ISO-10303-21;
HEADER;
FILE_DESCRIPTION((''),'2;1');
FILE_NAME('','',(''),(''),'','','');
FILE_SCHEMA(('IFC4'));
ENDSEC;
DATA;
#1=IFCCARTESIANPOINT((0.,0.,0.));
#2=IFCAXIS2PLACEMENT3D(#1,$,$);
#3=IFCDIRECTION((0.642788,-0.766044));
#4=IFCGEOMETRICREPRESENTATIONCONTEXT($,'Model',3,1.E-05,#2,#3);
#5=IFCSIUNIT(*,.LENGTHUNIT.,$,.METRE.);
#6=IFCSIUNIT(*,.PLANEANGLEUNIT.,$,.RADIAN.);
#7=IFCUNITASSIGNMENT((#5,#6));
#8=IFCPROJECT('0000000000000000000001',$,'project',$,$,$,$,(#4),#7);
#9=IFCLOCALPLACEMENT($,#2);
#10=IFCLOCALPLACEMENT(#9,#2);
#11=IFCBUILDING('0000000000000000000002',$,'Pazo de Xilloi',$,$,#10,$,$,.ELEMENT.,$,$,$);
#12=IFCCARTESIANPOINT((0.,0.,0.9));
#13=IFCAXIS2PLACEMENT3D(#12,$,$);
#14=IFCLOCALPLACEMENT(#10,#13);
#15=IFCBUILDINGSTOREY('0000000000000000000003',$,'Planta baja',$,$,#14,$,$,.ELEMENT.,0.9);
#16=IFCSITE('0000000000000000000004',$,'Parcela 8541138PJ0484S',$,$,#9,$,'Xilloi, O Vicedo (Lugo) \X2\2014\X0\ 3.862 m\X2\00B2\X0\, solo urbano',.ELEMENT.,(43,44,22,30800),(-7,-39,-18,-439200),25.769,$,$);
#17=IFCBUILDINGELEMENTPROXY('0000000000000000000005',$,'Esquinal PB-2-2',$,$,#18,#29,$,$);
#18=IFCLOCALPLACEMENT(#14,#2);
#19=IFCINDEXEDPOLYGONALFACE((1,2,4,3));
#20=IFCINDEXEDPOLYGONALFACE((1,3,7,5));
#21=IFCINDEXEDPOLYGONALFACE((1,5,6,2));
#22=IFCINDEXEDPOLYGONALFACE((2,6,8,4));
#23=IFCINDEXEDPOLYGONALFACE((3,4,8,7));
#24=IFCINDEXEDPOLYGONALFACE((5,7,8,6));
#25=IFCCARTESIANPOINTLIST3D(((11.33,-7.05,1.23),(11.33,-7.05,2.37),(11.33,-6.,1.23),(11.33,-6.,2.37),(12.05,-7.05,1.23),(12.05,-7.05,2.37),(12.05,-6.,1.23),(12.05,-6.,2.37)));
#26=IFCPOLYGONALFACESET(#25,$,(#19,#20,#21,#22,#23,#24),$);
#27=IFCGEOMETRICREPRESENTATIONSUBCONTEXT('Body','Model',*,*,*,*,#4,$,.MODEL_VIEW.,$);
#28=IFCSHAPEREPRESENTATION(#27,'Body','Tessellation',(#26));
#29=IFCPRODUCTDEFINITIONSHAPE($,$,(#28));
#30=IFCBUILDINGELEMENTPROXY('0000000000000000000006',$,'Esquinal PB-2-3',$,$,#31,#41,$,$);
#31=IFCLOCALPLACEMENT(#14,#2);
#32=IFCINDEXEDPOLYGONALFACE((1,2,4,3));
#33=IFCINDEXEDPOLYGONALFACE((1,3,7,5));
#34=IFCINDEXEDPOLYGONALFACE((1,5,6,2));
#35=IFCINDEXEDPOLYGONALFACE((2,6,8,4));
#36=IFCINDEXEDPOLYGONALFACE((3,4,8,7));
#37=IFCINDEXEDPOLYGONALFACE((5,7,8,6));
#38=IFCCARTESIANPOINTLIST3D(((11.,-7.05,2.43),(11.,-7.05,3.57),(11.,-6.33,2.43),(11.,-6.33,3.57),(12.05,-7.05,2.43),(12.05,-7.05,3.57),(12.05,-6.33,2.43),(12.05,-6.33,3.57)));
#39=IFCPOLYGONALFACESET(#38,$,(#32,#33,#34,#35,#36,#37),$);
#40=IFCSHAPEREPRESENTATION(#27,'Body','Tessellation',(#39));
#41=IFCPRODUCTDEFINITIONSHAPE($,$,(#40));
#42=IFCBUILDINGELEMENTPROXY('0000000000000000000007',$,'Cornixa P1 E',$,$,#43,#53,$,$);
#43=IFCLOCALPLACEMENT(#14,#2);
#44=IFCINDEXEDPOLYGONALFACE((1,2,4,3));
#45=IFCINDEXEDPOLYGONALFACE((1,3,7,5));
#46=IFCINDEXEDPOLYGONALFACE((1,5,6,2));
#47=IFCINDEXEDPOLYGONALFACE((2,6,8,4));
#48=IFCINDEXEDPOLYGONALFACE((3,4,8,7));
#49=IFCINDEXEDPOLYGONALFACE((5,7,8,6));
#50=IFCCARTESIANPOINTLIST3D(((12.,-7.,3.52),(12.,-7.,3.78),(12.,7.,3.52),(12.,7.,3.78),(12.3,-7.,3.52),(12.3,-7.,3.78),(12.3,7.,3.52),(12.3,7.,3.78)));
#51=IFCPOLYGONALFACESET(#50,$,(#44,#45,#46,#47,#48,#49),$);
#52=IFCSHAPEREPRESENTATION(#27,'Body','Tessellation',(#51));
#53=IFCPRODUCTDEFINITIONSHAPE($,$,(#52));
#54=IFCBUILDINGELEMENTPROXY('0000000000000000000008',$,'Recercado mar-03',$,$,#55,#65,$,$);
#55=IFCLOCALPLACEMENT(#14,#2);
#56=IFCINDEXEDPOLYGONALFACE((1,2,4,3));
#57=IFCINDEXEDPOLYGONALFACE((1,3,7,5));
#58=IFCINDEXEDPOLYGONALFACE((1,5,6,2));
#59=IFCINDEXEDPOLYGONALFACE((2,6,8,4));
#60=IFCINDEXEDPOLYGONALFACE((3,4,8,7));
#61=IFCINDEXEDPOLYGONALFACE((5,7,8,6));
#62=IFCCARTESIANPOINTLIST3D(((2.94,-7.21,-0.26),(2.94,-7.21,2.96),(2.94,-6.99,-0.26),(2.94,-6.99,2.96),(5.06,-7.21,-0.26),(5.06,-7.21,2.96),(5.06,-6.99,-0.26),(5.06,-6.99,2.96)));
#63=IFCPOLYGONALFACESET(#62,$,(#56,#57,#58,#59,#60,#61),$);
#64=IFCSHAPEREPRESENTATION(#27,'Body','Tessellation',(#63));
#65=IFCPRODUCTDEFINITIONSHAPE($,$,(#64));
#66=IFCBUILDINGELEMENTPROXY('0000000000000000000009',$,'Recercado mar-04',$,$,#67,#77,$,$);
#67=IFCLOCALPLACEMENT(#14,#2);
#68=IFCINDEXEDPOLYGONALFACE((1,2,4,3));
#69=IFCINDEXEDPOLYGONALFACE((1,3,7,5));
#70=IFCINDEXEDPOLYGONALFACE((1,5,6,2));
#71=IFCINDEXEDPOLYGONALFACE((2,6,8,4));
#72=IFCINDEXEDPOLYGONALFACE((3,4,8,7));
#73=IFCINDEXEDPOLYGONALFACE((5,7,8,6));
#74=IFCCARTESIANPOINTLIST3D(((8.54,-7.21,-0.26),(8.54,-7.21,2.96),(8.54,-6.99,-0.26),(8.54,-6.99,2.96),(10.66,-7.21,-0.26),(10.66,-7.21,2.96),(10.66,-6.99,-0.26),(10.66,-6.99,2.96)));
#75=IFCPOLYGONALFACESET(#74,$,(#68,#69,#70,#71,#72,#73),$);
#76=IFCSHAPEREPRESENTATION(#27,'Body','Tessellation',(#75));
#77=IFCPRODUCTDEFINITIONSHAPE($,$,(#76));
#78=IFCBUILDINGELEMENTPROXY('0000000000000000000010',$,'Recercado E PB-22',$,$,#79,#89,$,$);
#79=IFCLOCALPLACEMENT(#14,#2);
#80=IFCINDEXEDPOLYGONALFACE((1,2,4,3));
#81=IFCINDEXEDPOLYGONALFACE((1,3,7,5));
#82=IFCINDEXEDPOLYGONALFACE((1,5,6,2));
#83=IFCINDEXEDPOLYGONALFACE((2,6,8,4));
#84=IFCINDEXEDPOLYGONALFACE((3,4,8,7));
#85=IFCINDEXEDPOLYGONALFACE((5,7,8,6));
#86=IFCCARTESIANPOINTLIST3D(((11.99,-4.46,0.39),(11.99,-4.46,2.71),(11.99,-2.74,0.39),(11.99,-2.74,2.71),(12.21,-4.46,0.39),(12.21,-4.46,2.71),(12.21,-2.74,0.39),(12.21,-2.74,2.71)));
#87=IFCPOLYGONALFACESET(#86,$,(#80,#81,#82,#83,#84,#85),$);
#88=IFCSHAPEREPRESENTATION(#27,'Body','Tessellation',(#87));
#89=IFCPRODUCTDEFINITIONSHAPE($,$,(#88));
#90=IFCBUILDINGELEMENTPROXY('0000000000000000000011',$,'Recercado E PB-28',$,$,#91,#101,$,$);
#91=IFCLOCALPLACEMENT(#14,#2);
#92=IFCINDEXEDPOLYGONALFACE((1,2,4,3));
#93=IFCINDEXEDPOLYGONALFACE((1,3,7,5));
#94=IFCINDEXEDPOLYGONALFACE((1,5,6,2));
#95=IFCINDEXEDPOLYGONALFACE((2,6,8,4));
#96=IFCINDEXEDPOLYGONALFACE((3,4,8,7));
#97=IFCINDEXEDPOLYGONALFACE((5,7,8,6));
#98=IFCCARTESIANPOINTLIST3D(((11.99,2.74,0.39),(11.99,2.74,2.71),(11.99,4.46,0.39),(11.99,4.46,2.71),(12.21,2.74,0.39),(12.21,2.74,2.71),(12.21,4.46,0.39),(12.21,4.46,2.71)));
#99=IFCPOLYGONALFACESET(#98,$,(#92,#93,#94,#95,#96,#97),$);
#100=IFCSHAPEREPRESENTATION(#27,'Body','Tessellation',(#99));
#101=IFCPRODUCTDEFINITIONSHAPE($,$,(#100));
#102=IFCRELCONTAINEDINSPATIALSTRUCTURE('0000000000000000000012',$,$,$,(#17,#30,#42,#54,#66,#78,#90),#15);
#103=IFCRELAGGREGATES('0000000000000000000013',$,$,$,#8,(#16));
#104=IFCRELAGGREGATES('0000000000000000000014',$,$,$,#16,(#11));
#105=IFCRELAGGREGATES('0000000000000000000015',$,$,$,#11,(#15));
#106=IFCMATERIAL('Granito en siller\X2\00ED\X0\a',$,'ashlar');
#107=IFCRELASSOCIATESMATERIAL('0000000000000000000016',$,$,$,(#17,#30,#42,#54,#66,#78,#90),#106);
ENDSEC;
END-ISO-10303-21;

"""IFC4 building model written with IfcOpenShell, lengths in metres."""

from ifc_helpers import new_model, si_unit, direction, frame, origin, origin_2d, place, context, subcontext, project, spatial, rectangle, extrude, material, element, save


model = new_model("IFC4")

# Units and contexts
model_context = context("Model", 3, precision=1e-05, world=origin(), true_north=direction((0.642788, -0.766044)))
body_context = subcontext(model_context, "Body", "Model", "MODEL_VIEW")
ifc_project = project(units=[si_unit("LENGTHUNIT", "METRE"), si_unit("PLANEANGLEUNIT", "RADIAN")], contexts=[model_context])

# Site, building, storey
site_placement = place(None, origin())
site = spatial("IfcSite", under=ifc_project, at=site_placement, Name="Parcela 8541138PJ0484S", LongName="Xilloi, O Vicedo (Lugo) — 3.862 m², solo urbano", CompositionType="ELEMENT", RefLatitude=(43, 44, 22, 30800), RefLongitude=(-7, -39, -18, -439200), RefElevation=25.769)
building_placement = place(site_placement, origin())
building = spatial("IfcBuilding", under=site, at=building_placement, Name="Pazo de Xilloi", CompositionType="ELEMENT")
storey_placement = place(building_placement, frame((0.0, 0.0, 0.9)))
storey = spatial("IfcBuildingStorey", under=building, at=storey_placement, Name="Planta baja", CompositionType="ELEMENT", Elevation=0.9)

# Building element proxies
ifc_material_1 = material(Name="Granito en sillería", Category="ashlar")
proxy_1_placement = place(storey_placement, frame((11.69, -6.525, 1.8)))
element("IfcBuildingElementProxy", 1, at=proxy_1_placement, inside=storey, material=ifc_material_1, Name="Esquinal PB-2-2", context=body_context, shape_type="SweptSolid", body=[
    extrude(rectangle(XDim=0.72, YDim=1.05, at=origin_2d()), frame((0.0, 0.0, -0.57)), (0.0, 0.0, 1.0), 1.14),
])
proxy_2_placement = place(storey_placement, frame((11.525, -6.69, 3.0)))
element("IfcBuildingElementProxy", 2, at=proxy_2_placement, inside=storey, material=ifc_material_1, Name="Esquinal PB-2-3", context=body_context, shape_type="SweptSolid", body=[
    extrude(rectangle(XDim=1.05, YDim=0.72, at=origin_2d()), frame((0.0, 0.0, -0.57)), (0.0, 0.0, 1.0), 1.14),
])
proxy_3_placement = place(storey_placement, frame((12.15, 0.0, 3.65)))
element("IfcBuildingElementProxy", 3, at=proxy_3_placement, inside=storey, material=ifc_material_1, Name="Cornixa P1 E", context=body_context, shape_type="SweptSolid", body=[
    extrude(rectangle(XDim=0.3, YDim=14.0, at=origin_2d()), frame((0.0, 0.0, -0.13)), (0.0, 0.0, 1.0), 0.26),
])
for number, where, name in (
    (4, (4.0, -7.1, 1.35), "Recercado mar-03"),
    (5, (9.6, -7.1, 1.35), "Recercado mar-04"),
):
    element("IfcBuildingElementProxy", number, at=place(storey_placement, frame(where)), inside=storey, material=ifc_material_1, Name=name, context=body_context, shape_type="SweptSolid", body=[
        extrude(rectangle(XDim=2.12, YDim=0.22, at=origin_2d()), frame((0.0, 0.0, -1.61)), (0.0, 0.0, 1.0), 3.22),
    ])
for number, where, name in (
    (6, (12.1, -3.6, 1.55), "Recercado E PB-22"),
    (7, (12.1, 3.6, 1.55), "Recercado E PB-28"),
):
    element("IfcBuildingElementProxy", number, at=place(storey_placement, frame(where)), inside=storey, material=ifc_material_1, Name=name, context=body_context, shape_type="SweptSolid", body=[
        extrude(rectangle(XDim=0.22, YDim=1.72, at=origin_2d()), frame((0.0, 0.0, -1.16)), (0.0, 0.0, 1.0), 2.32),
    ])

save(model, "model.ifc")
